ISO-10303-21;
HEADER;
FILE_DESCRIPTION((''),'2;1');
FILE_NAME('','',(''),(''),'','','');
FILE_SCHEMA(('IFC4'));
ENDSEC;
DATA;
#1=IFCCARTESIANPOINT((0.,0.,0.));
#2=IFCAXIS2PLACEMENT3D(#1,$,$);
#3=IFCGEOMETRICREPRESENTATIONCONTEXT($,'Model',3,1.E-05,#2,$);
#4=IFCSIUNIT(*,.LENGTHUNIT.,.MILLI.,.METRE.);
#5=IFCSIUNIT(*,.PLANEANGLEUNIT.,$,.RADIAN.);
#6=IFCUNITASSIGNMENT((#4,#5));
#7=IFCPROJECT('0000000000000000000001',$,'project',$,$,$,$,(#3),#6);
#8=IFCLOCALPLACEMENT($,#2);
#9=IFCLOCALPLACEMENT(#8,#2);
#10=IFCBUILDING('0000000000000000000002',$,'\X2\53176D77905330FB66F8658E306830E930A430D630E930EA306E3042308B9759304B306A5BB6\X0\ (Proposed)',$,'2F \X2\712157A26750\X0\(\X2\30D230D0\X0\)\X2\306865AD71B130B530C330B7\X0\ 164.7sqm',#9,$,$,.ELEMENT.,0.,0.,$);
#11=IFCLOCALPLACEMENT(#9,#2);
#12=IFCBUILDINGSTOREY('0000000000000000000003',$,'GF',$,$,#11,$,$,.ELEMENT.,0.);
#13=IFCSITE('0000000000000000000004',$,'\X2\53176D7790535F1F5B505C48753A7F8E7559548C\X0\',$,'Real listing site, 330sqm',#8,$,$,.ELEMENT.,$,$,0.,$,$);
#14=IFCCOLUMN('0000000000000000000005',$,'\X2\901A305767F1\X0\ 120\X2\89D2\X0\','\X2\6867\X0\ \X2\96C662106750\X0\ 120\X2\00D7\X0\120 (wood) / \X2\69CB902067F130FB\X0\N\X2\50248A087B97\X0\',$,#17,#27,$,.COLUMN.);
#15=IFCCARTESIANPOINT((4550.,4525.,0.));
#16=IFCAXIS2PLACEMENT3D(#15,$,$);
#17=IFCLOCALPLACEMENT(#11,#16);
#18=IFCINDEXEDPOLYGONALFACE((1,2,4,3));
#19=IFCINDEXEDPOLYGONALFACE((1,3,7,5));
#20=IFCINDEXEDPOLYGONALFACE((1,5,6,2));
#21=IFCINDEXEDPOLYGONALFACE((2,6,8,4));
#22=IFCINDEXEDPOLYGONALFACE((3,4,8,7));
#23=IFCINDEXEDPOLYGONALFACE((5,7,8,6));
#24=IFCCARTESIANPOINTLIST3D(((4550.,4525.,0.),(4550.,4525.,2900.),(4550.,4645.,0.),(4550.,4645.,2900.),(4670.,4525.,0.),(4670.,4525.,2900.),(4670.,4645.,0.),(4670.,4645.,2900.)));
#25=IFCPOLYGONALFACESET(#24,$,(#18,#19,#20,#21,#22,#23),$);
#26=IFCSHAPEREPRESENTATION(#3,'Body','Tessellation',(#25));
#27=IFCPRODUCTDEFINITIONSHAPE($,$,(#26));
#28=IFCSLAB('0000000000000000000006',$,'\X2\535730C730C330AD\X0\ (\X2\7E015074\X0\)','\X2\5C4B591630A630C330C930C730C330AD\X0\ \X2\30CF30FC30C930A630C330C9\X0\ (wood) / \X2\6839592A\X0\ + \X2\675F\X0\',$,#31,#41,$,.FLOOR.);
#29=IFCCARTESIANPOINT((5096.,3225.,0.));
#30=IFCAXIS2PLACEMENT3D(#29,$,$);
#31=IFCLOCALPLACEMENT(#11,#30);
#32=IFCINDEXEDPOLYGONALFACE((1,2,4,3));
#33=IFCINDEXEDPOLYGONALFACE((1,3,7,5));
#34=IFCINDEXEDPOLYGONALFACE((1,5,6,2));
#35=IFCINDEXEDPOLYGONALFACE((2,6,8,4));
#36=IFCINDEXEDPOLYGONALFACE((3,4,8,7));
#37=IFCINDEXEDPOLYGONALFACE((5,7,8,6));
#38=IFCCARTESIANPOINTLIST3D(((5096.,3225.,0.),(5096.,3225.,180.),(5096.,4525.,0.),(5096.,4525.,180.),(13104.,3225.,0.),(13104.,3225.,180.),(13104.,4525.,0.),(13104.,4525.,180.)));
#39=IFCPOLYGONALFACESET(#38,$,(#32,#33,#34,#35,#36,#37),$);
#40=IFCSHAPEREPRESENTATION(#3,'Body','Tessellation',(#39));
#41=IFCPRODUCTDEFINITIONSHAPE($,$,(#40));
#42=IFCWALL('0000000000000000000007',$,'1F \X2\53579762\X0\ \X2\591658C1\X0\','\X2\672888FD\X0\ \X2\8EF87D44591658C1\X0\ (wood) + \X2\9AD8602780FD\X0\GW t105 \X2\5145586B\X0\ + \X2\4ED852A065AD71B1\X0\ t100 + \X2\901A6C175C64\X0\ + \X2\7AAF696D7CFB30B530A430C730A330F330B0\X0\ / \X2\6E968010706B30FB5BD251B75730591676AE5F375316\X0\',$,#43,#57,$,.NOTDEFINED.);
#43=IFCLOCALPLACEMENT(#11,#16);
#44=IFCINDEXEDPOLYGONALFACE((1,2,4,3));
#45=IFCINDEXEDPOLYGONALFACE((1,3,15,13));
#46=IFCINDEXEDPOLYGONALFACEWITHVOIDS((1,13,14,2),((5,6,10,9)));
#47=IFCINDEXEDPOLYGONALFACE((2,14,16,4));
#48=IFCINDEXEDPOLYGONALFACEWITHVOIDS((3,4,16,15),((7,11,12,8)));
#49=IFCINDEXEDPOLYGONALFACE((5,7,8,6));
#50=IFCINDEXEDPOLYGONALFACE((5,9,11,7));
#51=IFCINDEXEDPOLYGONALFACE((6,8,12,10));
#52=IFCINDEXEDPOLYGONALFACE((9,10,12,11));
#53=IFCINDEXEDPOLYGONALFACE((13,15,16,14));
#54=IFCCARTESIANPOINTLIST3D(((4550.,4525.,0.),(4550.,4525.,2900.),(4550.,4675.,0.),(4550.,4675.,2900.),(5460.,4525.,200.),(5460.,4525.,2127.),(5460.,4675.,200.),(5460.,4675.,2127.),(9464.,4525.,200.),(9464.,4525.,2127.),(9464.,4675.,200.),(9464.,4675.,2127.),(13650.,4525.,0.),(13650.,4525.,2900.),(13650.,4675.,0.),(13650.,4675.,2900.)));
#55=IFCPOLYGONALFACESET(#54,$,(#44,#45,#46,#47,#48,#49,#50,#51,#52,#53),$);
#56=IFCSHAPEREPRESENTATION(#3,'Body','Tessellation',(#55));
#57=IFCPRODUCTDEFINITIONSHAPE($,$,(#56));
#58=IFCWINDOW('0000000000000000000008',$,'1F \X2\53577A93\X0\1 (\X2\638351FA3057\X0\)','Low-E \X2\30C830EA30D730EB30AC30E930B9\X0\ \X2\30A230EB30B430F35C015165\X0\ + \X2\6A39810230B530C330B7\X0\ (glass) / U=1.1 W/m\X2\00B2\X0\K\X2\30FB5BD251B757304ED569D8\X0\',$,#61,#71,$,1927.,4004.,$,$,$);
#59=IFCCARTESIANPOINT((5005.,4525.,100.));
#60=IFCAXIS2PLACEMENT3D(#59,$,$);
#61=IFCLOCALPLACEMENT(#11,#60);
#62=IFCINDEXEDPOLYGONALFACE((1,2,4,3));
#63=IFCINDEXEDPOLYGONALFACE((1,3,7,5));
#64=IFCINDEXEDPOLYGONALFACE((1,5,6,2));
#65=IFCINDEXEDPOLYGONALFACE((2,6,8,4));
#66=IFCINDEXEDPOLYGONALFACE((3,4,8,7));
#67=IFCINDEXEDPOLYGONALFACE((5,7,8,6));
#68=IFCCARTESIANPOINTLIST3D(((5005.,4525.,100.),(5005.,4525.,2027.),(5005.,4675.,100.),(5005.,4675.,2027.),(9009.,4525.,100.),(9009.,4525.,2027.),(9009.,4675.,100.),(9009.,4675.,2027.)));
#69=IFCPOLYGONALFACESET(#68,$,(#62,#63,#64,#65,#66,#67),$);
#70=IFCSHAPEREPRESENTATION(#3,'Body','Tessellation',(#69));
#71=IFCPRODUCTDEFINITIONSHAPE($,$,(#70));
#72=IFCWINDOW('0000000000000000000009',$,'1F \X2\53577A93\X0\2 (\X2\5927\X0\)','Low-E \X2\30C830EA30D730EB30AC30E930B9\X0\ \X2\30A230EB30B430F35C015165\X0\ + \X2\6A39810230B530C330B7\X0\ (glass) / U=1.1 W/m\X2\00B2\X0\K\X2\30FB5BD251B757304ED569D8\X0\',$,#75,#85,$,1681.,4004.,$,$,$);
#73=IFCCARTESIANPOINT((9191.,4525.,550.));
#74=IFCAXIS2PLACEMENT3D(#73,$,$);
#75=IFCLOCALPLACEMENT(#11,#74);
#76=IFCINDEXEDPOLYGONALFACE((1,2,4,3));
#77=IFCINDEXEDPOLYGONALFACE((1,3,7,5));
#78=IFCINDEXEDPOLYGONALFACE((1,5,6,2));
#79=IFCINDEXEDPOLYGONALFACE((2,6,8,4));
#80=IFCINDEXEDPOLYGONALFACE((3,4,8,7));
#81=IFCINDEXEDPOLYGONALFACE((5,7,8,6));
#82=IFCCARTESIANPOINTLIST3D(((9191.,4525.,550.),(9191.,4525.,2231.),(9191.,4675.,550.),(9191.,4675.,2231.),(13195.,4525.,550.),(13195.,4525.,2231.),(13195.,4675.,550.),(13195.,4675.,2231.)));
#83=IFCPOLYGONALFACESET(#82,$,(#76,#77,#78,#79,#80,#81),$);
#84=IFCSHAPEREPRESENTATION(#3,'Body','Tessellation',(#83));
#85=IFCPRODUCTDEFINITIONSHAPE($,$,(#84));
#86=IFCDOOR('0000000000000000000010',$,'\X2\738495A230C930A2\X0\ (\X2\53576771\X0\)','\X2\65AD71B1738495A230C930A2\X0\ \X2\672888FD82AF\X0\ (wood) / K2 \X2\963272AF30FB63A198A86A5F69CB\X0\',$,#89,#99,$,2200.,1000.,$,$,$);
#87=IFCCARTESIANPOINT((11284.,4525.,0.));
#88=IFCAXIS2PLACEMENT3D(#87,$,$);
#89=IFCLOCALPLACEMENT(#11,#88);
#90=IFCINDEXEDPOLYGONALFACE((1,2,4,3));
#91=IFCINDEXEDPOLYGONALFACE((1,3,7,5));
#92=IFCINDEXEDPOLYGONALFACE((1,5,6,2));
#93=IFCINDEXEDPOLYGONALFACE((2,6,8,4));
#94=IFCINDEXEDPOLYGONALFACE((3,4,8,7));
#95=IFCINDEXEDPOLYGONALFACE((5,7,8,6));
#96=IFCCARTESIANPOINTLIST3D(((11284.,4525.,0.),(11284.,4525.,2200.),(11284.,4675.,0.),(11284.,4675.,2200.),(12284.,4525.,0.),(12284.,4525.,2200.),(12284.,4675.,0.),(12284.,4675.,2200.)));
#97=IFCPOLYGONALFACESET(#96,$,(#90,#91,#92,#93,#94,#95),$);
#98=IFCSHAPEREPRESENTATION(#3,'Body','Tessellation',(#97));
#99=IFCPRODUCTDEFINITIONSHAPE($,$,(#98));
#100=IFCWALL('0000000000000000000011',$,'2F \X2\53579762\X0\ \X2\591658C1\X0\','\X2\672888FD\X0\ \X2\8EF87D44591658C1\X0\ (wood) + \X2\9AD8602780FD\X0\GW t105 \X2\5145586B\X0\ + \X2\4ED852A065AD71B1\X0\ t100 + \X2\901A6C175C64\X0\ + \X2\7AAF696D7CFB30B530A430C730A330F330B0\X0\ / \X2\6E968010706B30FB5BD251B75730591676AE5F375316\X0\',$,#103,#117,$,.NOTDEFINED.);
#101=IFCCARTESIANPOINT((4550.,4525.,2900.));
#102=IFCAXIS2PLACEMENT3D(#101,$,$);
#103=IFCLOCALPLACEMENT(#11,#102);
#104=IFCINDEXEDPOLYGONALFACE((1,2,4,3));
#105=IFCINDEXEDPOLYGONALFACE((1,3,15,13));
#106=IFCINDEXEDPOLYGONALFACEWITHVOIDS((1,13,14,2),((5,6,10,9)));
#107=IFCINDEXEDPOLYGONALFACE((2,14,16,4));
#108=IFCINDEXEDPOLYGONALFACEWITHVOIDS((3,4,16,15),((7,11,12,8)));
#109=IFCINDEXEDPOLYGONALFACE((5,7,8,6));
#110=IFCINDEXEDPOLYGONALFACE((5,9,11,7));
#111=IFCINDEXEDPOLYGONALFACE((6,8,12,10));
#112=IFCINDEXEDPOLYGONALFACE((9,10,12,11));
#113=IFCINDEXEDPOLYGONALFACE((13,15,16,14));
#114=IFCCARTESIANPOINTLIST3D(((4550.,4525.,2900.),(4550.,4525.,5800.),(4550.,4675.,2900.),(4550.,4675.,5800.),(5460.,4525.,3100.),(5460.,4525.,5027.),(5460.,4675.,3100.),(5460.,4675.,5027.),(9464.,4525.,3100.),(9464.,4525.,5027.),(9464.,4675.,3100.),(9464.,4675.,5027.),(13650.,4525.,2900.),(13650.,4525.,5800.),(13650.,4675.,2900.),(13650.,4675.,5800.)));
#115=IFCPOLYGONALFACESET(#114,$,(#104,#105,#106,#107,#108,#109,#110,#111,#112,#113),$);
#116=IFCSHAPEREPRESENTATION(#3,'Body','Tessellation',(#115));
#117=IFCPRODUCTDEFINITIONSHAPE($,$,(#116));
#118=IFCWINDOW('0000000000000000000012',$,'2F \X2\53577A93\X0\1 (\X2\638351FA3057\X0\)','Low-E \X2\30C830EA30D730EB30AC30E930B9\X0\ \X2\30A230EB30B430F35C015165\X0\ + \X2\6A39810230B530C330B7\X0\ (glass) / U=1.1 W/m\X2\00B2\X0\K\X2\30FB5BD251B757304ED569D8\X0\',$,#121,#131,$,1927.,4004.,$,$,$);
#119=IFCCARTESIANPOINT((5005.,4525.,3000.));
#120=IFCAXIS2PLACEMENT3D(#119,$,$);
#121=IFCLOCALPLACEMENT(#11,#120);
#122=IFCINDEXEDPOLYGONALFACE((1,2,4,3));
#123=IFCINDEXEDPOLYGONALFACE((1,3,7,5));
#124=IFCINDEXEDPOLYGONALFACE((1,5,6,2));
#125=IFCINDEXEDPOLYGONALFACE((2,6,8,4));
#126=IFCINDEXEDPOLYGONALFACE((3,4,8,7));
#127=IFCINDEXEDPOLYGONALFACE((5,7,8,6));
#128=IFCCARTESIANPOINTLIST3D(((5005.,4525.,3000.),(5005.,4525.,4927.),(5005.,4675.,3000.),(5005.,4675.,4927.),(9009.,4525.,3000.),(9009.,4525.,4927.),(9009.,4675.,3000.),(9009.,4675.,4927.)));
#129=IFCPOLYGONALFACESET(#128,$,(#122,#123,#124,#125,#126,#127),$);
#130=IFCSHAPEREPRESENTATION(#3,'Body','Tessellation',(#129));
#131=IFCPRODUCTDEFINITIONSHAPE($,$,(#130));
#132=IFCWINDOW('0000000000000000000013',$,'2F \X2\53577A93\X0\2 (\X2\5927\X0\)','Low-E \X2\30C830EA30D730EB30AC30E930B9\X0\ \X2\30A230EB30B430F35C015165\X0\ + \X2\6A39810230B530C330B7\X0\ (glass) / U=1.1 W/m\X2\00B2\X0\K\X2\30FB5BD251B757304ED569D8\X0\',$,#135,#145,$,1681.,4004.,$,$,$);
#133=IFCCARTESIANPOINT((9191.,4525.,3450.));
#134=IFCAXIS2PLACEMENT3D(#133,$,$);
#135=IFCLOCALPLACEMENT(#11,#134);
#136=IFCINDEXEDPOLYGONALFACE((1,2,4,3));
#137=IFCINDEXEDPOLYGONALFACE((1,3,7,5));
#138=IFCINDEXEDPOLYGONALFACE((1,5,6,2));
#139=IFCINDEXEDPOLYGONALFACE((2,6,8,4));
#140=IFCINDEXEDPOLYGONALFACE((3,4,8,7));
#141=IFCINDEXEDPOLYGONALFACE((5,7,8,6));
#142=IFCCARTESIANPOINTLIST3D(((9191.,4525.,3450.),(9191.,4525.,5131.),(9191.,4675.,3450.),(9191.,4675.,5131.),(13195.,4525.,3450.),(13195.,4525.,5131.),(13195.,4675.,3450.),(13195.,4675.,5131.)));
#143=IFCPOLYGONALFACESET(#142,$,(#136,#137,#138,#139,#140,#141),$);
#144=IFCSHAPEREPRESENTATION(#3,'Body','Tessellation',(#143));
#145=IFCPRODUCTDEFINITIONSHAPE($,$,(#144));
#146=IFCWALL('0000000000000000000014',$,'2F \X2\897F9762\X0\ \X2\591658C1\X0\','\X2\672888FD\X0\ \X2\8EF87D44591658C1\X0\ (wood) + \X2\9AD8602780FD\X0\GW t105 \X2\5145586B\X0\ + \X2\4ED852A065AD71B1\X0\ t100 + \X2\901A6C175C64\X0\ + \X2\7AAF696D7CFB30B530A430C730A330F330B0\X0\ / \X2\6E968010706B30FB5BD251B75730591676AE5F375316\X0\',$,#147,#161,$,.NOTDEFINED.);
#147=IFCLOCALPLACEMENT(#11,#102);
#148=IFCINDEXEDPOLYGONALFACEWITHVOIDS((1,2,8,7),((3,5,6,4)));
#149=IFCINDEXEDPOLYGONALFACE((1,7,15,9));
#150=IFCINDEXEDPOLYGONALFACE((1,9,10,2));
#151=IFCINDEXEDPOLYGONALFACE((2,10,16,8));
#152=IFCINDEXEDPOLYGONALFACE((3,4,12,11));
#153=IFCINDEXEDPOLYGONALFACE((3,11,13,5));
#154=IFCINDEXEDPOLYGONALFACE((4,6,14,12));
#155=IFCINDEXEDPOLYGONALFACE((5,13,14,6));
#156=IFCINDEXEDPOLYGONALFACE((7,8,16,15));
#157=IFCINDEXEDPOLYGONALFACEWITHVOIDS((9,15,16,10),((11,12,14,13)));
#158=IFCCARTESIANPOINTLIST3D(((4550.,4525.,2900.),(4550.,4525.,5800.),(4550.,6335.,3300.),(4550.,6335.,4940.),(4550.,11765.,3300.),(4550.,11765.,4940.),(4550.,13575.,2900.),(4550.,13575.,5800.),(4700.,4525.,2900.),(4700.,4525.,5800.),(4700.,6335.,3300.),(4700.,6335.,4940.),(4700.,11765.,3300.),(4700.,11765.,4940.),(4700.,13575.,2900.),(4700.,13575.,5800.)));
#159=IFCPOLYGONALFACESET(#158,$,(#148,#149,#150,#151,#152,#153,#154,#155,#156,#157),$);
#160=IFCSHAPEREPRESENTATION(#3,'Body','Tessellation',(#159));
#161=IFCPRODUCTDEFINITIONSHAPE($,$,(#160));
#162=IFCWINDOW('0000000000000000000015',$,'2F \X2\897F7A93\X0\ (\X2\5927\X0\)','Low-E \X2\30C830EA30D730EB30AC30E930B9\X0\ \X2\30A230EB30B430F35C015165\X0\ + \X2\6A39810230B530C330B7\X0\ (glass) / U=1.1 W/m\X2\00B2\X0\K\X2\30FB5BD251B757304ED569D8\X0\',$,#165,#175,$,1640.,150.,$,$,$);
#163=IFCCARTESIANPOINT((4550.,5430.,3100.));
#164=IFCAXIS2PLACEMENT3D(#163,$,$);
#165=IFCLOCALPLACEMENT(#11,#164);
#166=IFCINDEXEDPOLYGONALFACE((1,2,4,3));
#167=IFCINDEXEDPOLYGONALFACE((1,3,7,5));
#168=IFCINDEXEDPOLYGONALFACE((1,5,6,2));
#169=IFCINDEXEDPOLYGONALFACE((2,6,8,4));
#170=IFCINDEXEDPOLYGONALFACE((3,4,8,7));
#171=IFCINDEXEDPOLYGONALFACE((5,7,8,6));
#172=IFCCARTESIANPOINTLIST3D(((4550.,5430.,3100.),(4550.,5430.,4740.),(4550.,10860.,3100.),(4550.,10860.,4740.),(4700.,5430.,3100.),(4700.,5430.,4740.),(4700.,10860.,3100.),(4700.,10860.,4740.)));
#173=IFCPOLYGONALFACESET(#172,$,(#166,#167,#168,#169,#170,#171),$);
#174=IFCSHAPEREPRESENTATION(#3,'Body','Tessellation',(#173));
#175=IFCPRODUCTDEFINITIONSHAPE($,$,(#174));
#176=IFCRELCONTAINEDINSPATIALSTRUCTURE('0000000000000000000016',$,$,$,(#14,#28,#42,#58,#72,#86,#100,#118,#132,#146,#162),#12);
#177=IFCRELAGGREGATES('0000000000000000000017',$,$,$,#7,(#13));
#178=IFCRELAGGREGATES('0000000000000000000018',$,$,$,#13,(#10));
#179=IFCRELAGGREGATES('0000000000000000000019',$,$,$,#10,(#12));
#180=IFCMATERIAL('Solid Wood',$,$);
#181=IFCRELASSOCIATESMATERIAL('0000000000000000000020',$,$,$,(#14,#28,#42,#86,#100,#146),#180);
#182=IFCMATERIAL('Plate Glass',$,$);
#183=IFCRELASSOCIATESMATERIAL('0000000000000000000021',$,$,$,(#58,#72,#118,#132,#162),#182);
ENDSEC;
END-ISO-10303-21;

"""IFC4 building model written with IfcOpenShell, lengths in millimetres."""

from ifc_helpers import new_model, si_unit, frame, frame_2d, origin, place, context, project, spatial, rectangle, extrude, material, element, fill, save


model = new_model("IFC4")

# Units and contexts
model_context = context("Model", 3, precision=1e-05, world=origin())
ifc_project = project(units=[si_unit("LENGTHUNIT", "METRE", prefix="MILLI"), si_unit("PLANEANGLEUNIT", "RADIAN")], contexts=[model_context])

# Site, building, storey
site_placement = place(None, origin())
site = spatial("IfcSite", under=ifc_project, at=site_placement, Name="北海道弟子屈町美留和", ObjectType="Real listing site, 330sqm", CompositionType="ELEMENT", RefElevation=0.0)
building_placement = place(site_placement, origin())
building = spatial("IfcBuilding", under=site, at=building_placement, Name="北海道・書斎とライブラリのある静かな家 (Proposed)", ObjectType="2F 無垢材(ヒバ)と断熱サッシ 164.7sqm", CompositionType="ELEMENT", ElevationOfRefHeight=0.0, ElevationOfTerrain=0.0)
storey_placement = place(building_placement, origin())
storey = spatial("IfcBuildingStorey", under=building, at=storey_placement, Name="GF", CompositionType="ELEMENT", Elevation=0.0)

# Column
ifc_material_1 = material(Name="Solid Wood")
column_placement = place(storey_placement, frame((4550.0, 4525.0, 0.0)))
element("IfcColumn", 1, at=column_placement, inside=storey, material=ifc_material_1, Name="通し柱 120角", Description="桧 集成材 120×120 (wood) / 構造柱・N値計算", PredefinedType="COLUMN", context=model_context, shape_type="SweptSolid", body=[
    extrude(rectangle(XDim=120.0, YDim=120.0, at=frame_2d((60.0, 60.0))), frame((4550.0, 4525.0, 0.0)), (0.0, 0.0, 1.0), 2900.0),
])

# Slab
slab_1_placement = place(storey_placement, frame((5096.0, 3225.0, 0.0)))
element("IfcSlab", 2, at=slab_1_placement, inside=storey, material=ifc_material_1, Name="南デッキ (縁側)", Description="屋外ウッドデッキ ハードウッド (wood) / 根太 + 束", PredefinedType="FLOOR", context=model_context, shape_type="SweptSolid", body=[
    extrude(rectangle(XDim=8008.0, YDim=1300.0, at=frame_2d((4004.0, 650.0))), frame((5096.0, 3225.0, 0.0)), (0.0, 0.0, 1.0), 180.0),
])

# Wall, openings, windows, door
wall_1_placement = place(storey_placement, frame((4550.0, 4525.0, 0.0)))
wall_1 = element("IfcWall", 3, at=wall_1_placement, inside=storey, material=ifc_material_1, Name="1F 南面 外壁", Description="木製 軸組外壁 (wood) + 高性能GW t105 充填 + 付加断熱 t100 + 通気層 + 窯業系サイディング / 準耐火・寒冷地外皮強化", PredefinedType="NOTDEFINED", context=model_context, shape_type="SweptSolid", body=[
    extrude(rectangle(XDim=9100.0, YDim=150.0, at=frame_2d((4550.0, 75.0))), frame((4550.0, 4525.0, 0.0)), (0.0, 0.0, 1.0), 2900.0),
])
opening_1_placement = place(storey_placement, frame((5005.0, 4525.0, 100.0)))
opening_1 = element("IfcOpeningElement", 4, at=opening_1_placement, cuts=wall_1, PredefinedType="NOTDEFINED", context=model_context, shape_type="SweptSolid", body=[
    extrude(rectangle(XDim=4004.0, YDim=150.0, at=frame_2d((2002.0, 75.0))), frame((5005.0, 4525.0, 100.0)), (0.0, 0.0, 1.0), 1927.0),
])
opening_2_placement = place(storey_placement, frame((9191.0, 4525.0, 550.0)))
opening_2 = element("IfcOpeningElement", 5, at=opening_2_placement, cuts=wall_1, PredefinedType="NOTDEFINED", context=model_context, shape_type="SweptSolid", body=[
    extrude(rectangle(XDim=4004.0, YDim=150.0, at=frame_2d((2002.0, 75.0))), frame((9191.0, 4525.0, 550.0)), (0.0, 0.0, 1.0), 1681.0),
])
opening_3_placement = place(storey_placement, frame((11284.0, 4525.0, 0.0)))
opening_3 = element("IfcOpeningElement", 6, at=opening_3_placement, cuts=wall_1, PredefinedType="NOTDEFINED", context=model_context, shape_type="SweptSolid", body=[
    extrude(rectangle(XDim=1000.0, YDim=150.0, at=frame_2d((500.0, 75.0))), frame((11284.0, 4525.0, 0.0)), (0.0, 0.0, 1.0), 2200.0),
])
ifc_material_2 = material(Name="Plate Glass")
window_1_placement = place(storey_placement, frame((5005.0, 4525.0, 100.0)))
window_1 = element("IfcWindow", 7, at=window_1_placement, inside=storey, material=ifc_material_2, Name="1F 南窓1 (掃出し)", Description="Low-E トリプルガラス アルゴン封入 + 樹脂サッシ (glass) / U=1.1 W/m²K・寒冷地仕様", OverallHeight=1927.0, OverallWidth=4004.0, context=model_context, shape_type="SweptSolid", body=[
    extrude(rectangle(XDim=4004.0, YDim=150.0, at=frame_2d((2002.0, 75.0))), frame((5005.0, 4525.0, 100.0)), (0.0, 0.0, 1.0), 1927.0),
])
fill(opening_1, window_1)
window_2_placement = place(storey_placement, frame((9191.0, 4525.0, 550.0)))
window_2 = element("IfcWindow", 8, at=window_2_placement, inside=storey, material=ifc_material_2, Name="1F 南窓2 (大)", Description="Low-E トリプルガラス アルゴン封入 + 樹脂サッシ (glass) / U=1.1 W/m²K・寒冷地仕様", OverallHeight=1681.0, OverallWidth=4004.0, context=model_context, shape_type="SweptSolid", body=[
    extrude(rectangle(XDim=4004.0, YDim=150.0, at=frame_2d((2002.0, 75.0))), frame((9191.0, 4525.0, 550.0)), (0.0, 0.0, 1.0), 1681.0),
])
fill(opening_2, window_2)
door_placement = place(storey_placement, frame((11284.0, 4525.0, 0.0)))
door = element("IfcDoor", 9, at=door_placement, inside=storey, material=ifc_material_1, Name="玄関ドア (南東)", Description="断熱玄関ドア 木製芯 (wood) / K2 防犯・採風機構", OverallHeight=2200.0, OverallWidth=1000.0, context=model_context, shape_type="SweptSolid", body=[
    extrude(rectangle(XDim=1000.0, YDim=150.0, at=frame_2d((500.0, 75.0))), frame((11284.0, 4525.0, 0.0)), (0.0, 0.0, 1.0), 2200.0),
])
fill(opening_3, door)

# Wall, openings, windows
wall_2_placement = place(storey_placement, frame((4550.0, 4525.0, 2900.0)))
wall_2 = element("IfcWall", 10, at=wall_2_placement, inside=storey, material=ifc_material_1, Name="2F 南面 外壁", Description="木製 軸組外壁 (wood) + 高性能GW t105 充填 + 付加断熱 t100 + 通気層 + 窯業系サイディング / 準耐火・寒冷地外皮強化", PredefinedType="NOTDEFINED", context=model_context, shape_type="SweptSolid", body=[
    extrude(rectangle(XDim=9100.0, YDim=150.0, at=frame_2d((4550.0, 75.0))), frame((4550.0, 4525.0, 2900.0)), (0.0, 0.0, 1.0), 2900.0),
])
opening_4_placement = place(storey_placement, frame((5005.0, 4525.0, 3000.0)))
opening_4 = element("IfcOpeningElement", 11, at=opening_4_placement, cuts=wall_2, PredefinedType="NOTDEFINED", context=model_context, shape_type="SweptSolid", body=[
    extrude(rectangle(XDim=4004.0, YDim=150.0, at=frame_2d((2002.0, 75.0))), frame((5005.0, 4525.0, 3000.0)), (0.0, 0.0, 1.0), 1927.0),
])
opening_5_placement = place(storey_placement, frame((9191.0, 4525.0, 3450.0)))
opening_5 = element("IfcOpeningElement", 12, at=opening_5_placement, cuts=wall_2, PredefinedType="NOTDEFINED", context=model_context, shape_type="SweptSolid", body=[
    extrude(rectangle(XDim=4004.0, YDim=150.0, at=frame_2d((2002.0, 75.0))), frame((9191.0, 4525.0, 3450.0)), (0.0, 0.0, 1.0), 1681.0),
])
window_3_placement = place(storey_placement, frame((5005.0, 4525.0, 3000.0)))
window_3 = element("IfcWindow", 13, at=window_3_placement, inside=storey, material=ifc_material_2, Name="2F 南窓1 (掃出し)", Description="Low-E トリプルガラス アルゴン封入 + 樹脂サッシ (glass) / U=1.1 W/m²K・寒冷地仕様", OverallHeight=1927.0, OverallWidth=4004.0, context=model_context, shape_type="SweptSolid", body=[
    extrude(rectangle(XDim=4004.0, YDim=150.0, at=frame_2d((2002.0, 75.0))), frame((5005.0, 4525.0, 3000.0)), (0.0, 0.0, 1.0), 1927.0),
])
fill(opening_4, window_3)
window_4_placement = place(storey_placement, frame((9191.0, 4525.0, 3450.0)))
window_4 = element("IfcWindow", 14, at=window_4_placement, inside=storey, material=ifc_material_2, Name="2F 南窓2 (大)", Description="Low-E トリプルガラス アルゴン封入 + 樹脂サッシ (glass) / U=1.1 W/m²K・寒冷地仕様", OverallHeight=1681.0, OverallWidth=4004.0, context=model_context, shape_type="SweptSolid", body=[
    extrude(rectangle(XDim=4004.0, YDim=150.0, at=frame_2d((2002.0, 75.0))), frame((9191.0, 4525.0, 3450.0)), (0.0, 0.0, 1.0), 1681.0),
])
fill(opening_5, window_4)

# Wall, opening, window
wall_3_placement = place(storey_placement, frame((4550.0, 4525.0, 2900.0)))
wall_3 = element("IfcWall", 15, at=wall_3_placement, inside=storey, material=ifc_material_1, Name="2F 西面 外壁", Description="木製 軸組外壁 (wood) + 高性能GW t105 充填 + 付加断熱 t100 + 通気層 + 窯業系サイディング / 準耐火・寒冷地外皮強化", PredefinedType="NOTDEFINED", context=model_context, shape_type="SweptSolid", body=[
    extrude(rectangle(XDim=150.0, YDim=9050.0, at=frame_2d((75.0, 4525.0))), frame((4550.0, 4525.0, 2900.0)), (0.0, 0.0, 1.0), 2900.0),
])
opening_6_placement = place(storey_placement, frame((4550.0, 5430.0, 3100.0)))
opening_6 = element("IfcOpeningElement", 16, at=opening_6_placement, cuts=wall_3, PredefinedType="NOTDEFINED", context=model_context, shape_type="SweptSolid", body=[
    extrude(rectangle(XDim=150.0, YDim=5430.0, at=frame_2d((75.0, 2715.0))), frame((4550.0, 5430.0, 3100.0)), (0.0, 0.0, 1.0), 1640.0),
])
window_5_placement = place(storey_placement, frame((4550.0, 5430.0, 3100.0)))
window_5 = element("IfcWindow", 17, at=window_5_placement, inside=storey, material=ifc_material_2, Name="2F 西窓 (大)", Description="Low-E トリプルガラス アルゴン封入 + 樹脂サッシ (glass) / U=1.1 W/m²K・寒冷地仕様", OverallHeight=1640.0, OverallWidth=150.0, context=model_context, shape_type="SweptSolid", body=[
    extrude(rectangle(XDim=150.0, YDim=5430.0, at=frame_2d((75.0, 2715.0))), frame((4550.0, 5430.0, 3100.0)), (0.0, 0.0, 1.0), 1640.0),
])
fill(opening_6, window_5)

save(model, "model.ifc")
